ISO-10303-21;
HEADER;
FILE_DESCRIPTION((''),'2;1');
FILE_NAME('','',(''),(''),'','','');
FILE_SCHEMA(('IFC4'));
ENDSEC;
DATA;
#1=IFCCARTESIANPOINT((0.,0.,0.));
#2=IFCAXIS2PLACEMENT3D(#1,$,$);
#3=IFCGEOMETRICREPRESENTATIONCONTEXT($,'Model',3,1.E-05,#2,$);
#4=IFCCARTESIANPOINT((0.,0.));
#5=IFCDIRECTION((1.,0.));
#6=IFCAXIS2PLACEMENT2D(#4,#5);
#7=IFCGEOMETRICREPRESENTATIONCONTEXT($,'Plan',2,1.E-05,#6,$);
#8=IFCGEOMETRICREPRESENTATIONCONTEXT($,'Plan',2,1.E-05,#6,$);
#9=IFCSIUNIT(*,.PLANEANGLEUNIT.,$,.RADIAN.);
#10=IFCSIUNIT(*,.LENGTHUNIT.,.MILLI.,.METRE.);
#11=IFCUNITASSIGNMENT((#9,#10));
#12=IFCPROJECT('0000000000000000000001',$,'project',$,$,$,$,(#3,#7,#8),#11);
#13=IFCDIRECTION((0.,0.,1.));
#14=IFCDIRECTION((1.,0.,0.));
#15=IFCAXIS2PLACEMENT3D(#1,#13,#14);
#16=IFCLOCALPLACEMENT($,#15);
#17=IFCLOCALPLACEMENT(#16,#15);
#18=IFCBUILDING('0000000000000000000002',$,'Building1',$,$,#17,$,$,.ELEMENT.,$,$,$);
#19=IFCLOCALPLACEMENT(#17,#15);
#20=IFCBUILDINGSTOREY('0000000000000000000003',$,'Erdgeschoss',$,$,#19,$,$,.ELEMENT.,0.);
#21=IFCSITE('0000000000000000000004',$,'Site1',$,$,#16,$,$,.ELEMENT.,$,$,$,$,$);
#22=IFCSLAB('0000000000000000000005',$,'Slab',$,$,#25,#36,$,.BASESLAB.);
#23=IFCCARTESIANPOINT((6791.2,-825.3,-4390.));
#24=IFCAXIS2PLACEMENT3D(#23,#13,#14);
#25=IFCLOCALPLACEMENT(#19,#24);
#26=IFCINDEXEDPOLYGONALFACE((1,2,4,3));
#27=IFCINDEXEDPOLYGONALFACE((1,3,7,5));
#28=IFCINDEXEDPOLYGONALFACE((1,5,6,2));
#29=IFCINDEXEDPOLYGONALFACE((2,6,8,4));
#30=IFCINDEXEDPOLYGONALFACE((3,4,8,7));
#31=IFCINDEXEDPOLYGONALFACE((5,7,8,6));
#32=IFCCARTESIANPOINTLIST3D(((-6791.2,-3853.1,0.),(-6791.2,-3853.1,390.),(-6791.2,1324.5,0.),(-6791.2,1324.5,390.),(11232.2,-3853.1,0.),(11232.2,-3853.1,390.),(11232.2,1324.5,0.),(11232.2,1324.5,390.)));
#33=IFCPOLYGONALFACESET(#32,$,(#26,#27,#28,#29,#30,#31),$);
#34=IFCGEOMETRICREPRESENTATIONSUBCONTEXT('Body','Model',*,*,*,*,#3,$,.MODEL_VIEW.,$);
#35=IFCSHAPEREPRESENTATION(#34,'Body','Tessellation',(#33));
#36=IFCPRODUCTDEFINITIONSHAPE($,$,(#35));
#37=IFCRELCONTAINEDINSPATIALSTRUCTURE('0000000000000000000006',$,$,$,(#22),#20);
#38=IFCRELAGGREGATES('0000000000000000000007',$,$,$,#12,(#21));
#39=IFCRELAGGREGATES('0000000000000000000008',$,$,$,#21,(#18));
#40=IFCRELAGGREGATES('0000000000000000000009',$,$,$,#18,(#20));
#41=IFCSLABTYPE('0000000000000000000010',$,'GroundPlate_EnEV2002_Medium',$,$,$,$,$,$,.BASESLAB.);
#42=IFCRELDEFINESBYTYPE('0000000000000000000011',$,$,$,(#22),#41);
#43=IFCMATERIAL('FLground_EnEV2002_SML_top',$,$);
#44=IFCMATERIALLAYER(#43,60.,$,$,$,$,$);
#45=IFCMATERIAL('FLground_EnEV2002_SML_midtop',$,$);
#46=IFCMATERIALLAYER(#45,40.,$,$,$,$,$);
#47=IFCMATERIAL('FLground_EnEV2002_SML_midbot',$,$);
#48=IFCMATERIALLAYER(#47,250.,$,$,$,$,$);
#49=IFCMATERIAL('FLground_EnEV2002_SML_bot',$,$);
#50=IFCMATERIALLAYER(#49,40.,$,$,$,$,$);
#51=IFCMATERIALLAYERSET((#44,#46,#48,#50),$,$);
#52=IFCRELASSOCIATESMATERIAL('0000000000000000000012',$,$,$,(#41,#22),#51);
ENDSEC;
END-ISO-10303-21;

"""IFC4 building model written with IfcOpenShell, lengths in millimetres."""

from ifc_helpers import new_model, si_unit, frame, origin, origin_with_axes, origin_2d_with_axis, place, context, subcontext, project, spatial, line, indexed_curve, outline, extrude, material, layer, layer_set, layer_usage, type_object, element, save


model = new_model("IFC4")

# Units and contexts
model_context = context("Model", 3, precision=1e-05, world=origin())
plan_context_1 = context("Plan", 2, precision=1e-05, world=origin_2d_with_axis())
plan_context_2 = context("Plan", 2, precision=1e-05, world=origin_2d_with_axis())
body_context = subcontext(model_context, "Body", "Model", "MODEL_VIEW")
ifc_project = project(units=[si_unit("PLANEANGLEUNIT", "RADIAN"), si_unit("LENGTHUNIT", "METRE", prefix="MILLI")], contexts=[model_context, plan_context_1, plan_context_2])

# Site, building, storey
site_placement = place(None, origin_with_axes())
site = spatial("IfcSite", under=ifc_project, at=site_placement, Name="Site1", CompositionType="ELEMENT")
building_placement = place(site_placement, origin_with_axes())
building = spatial("IfcBuilding", under=site, at=building_placement, Name="Building1", CompositionType="ELEMENT")
storey_placement = place(building_placement, origin_with_axes())
storey = spatial("IfcBuildingStorey", under=building, at=storey_placement, Name="Erdgeschoss", CompositionType="ELEMENT", Elevation=0.0)

# Slab
ifc_material_1 = material(Name="FLground_EnEV2002_SML_top")
ifc_layer_1 = layer(ifc_material_1, 60.0)
ifc_material_2 = material(Name="FLground_EnEV2002_SML_midtop")
ifc_layer_2 = layer(ifc_material_2, 40.0)
ifc_material_3 = material(Name="FLground_EnEV2002_SML_midbot")
ifc_layer_3 = layer(ifc_material_3, 250.0)
ifc_material_4 = material(Name="FLground_EnEV2002_SML_bot")
ifc_layer_4 = layer(ifc_material_4, 40.0)
ifc_layer_set_1 = layer_set([ifc_layer_1, ifc_layer_2, ifc_layer_3, ifc_layer_4])
ifc_layer_usage_1 = layer_usage(ifc_layer_set_1, "AXIS3", "POSITIVE", 0.0)
slab_type = type_object("IfcSlabType", Name="GroundPlate_EnEV2002_Medium", PredefinedType="BASESLAB", material=ifc_layer_set_1)
slab_placement = place(storey_placement, frame((6791.2, -825.3, -4390.0), z_axis=(0.0, 0.0, 1.0), x_axis=(1.0, 0.0, 0.0)))
element("IfcSlab", 1, at=slab_placement, inside=storey, type_object=slab_type, material=ifc_layer_usage_1, Name="Slab", PredefinedType="BASESLAB", context=body_context, shape_type="SweptSolid", body=[
    extrude(outline(indexed_curve([(-6791.2, -3853.1), (11232.2, -3853.1), (11232.2, 1324.5), (-6791.2, 1324.5)], segments=[line(4, 1), line(1, 2), line(2, 3), line(3, 4)], self_intersect=False)), None, (0.0, 0.0, 1.0), 390.0),
])

save(model, "model.ifc")
